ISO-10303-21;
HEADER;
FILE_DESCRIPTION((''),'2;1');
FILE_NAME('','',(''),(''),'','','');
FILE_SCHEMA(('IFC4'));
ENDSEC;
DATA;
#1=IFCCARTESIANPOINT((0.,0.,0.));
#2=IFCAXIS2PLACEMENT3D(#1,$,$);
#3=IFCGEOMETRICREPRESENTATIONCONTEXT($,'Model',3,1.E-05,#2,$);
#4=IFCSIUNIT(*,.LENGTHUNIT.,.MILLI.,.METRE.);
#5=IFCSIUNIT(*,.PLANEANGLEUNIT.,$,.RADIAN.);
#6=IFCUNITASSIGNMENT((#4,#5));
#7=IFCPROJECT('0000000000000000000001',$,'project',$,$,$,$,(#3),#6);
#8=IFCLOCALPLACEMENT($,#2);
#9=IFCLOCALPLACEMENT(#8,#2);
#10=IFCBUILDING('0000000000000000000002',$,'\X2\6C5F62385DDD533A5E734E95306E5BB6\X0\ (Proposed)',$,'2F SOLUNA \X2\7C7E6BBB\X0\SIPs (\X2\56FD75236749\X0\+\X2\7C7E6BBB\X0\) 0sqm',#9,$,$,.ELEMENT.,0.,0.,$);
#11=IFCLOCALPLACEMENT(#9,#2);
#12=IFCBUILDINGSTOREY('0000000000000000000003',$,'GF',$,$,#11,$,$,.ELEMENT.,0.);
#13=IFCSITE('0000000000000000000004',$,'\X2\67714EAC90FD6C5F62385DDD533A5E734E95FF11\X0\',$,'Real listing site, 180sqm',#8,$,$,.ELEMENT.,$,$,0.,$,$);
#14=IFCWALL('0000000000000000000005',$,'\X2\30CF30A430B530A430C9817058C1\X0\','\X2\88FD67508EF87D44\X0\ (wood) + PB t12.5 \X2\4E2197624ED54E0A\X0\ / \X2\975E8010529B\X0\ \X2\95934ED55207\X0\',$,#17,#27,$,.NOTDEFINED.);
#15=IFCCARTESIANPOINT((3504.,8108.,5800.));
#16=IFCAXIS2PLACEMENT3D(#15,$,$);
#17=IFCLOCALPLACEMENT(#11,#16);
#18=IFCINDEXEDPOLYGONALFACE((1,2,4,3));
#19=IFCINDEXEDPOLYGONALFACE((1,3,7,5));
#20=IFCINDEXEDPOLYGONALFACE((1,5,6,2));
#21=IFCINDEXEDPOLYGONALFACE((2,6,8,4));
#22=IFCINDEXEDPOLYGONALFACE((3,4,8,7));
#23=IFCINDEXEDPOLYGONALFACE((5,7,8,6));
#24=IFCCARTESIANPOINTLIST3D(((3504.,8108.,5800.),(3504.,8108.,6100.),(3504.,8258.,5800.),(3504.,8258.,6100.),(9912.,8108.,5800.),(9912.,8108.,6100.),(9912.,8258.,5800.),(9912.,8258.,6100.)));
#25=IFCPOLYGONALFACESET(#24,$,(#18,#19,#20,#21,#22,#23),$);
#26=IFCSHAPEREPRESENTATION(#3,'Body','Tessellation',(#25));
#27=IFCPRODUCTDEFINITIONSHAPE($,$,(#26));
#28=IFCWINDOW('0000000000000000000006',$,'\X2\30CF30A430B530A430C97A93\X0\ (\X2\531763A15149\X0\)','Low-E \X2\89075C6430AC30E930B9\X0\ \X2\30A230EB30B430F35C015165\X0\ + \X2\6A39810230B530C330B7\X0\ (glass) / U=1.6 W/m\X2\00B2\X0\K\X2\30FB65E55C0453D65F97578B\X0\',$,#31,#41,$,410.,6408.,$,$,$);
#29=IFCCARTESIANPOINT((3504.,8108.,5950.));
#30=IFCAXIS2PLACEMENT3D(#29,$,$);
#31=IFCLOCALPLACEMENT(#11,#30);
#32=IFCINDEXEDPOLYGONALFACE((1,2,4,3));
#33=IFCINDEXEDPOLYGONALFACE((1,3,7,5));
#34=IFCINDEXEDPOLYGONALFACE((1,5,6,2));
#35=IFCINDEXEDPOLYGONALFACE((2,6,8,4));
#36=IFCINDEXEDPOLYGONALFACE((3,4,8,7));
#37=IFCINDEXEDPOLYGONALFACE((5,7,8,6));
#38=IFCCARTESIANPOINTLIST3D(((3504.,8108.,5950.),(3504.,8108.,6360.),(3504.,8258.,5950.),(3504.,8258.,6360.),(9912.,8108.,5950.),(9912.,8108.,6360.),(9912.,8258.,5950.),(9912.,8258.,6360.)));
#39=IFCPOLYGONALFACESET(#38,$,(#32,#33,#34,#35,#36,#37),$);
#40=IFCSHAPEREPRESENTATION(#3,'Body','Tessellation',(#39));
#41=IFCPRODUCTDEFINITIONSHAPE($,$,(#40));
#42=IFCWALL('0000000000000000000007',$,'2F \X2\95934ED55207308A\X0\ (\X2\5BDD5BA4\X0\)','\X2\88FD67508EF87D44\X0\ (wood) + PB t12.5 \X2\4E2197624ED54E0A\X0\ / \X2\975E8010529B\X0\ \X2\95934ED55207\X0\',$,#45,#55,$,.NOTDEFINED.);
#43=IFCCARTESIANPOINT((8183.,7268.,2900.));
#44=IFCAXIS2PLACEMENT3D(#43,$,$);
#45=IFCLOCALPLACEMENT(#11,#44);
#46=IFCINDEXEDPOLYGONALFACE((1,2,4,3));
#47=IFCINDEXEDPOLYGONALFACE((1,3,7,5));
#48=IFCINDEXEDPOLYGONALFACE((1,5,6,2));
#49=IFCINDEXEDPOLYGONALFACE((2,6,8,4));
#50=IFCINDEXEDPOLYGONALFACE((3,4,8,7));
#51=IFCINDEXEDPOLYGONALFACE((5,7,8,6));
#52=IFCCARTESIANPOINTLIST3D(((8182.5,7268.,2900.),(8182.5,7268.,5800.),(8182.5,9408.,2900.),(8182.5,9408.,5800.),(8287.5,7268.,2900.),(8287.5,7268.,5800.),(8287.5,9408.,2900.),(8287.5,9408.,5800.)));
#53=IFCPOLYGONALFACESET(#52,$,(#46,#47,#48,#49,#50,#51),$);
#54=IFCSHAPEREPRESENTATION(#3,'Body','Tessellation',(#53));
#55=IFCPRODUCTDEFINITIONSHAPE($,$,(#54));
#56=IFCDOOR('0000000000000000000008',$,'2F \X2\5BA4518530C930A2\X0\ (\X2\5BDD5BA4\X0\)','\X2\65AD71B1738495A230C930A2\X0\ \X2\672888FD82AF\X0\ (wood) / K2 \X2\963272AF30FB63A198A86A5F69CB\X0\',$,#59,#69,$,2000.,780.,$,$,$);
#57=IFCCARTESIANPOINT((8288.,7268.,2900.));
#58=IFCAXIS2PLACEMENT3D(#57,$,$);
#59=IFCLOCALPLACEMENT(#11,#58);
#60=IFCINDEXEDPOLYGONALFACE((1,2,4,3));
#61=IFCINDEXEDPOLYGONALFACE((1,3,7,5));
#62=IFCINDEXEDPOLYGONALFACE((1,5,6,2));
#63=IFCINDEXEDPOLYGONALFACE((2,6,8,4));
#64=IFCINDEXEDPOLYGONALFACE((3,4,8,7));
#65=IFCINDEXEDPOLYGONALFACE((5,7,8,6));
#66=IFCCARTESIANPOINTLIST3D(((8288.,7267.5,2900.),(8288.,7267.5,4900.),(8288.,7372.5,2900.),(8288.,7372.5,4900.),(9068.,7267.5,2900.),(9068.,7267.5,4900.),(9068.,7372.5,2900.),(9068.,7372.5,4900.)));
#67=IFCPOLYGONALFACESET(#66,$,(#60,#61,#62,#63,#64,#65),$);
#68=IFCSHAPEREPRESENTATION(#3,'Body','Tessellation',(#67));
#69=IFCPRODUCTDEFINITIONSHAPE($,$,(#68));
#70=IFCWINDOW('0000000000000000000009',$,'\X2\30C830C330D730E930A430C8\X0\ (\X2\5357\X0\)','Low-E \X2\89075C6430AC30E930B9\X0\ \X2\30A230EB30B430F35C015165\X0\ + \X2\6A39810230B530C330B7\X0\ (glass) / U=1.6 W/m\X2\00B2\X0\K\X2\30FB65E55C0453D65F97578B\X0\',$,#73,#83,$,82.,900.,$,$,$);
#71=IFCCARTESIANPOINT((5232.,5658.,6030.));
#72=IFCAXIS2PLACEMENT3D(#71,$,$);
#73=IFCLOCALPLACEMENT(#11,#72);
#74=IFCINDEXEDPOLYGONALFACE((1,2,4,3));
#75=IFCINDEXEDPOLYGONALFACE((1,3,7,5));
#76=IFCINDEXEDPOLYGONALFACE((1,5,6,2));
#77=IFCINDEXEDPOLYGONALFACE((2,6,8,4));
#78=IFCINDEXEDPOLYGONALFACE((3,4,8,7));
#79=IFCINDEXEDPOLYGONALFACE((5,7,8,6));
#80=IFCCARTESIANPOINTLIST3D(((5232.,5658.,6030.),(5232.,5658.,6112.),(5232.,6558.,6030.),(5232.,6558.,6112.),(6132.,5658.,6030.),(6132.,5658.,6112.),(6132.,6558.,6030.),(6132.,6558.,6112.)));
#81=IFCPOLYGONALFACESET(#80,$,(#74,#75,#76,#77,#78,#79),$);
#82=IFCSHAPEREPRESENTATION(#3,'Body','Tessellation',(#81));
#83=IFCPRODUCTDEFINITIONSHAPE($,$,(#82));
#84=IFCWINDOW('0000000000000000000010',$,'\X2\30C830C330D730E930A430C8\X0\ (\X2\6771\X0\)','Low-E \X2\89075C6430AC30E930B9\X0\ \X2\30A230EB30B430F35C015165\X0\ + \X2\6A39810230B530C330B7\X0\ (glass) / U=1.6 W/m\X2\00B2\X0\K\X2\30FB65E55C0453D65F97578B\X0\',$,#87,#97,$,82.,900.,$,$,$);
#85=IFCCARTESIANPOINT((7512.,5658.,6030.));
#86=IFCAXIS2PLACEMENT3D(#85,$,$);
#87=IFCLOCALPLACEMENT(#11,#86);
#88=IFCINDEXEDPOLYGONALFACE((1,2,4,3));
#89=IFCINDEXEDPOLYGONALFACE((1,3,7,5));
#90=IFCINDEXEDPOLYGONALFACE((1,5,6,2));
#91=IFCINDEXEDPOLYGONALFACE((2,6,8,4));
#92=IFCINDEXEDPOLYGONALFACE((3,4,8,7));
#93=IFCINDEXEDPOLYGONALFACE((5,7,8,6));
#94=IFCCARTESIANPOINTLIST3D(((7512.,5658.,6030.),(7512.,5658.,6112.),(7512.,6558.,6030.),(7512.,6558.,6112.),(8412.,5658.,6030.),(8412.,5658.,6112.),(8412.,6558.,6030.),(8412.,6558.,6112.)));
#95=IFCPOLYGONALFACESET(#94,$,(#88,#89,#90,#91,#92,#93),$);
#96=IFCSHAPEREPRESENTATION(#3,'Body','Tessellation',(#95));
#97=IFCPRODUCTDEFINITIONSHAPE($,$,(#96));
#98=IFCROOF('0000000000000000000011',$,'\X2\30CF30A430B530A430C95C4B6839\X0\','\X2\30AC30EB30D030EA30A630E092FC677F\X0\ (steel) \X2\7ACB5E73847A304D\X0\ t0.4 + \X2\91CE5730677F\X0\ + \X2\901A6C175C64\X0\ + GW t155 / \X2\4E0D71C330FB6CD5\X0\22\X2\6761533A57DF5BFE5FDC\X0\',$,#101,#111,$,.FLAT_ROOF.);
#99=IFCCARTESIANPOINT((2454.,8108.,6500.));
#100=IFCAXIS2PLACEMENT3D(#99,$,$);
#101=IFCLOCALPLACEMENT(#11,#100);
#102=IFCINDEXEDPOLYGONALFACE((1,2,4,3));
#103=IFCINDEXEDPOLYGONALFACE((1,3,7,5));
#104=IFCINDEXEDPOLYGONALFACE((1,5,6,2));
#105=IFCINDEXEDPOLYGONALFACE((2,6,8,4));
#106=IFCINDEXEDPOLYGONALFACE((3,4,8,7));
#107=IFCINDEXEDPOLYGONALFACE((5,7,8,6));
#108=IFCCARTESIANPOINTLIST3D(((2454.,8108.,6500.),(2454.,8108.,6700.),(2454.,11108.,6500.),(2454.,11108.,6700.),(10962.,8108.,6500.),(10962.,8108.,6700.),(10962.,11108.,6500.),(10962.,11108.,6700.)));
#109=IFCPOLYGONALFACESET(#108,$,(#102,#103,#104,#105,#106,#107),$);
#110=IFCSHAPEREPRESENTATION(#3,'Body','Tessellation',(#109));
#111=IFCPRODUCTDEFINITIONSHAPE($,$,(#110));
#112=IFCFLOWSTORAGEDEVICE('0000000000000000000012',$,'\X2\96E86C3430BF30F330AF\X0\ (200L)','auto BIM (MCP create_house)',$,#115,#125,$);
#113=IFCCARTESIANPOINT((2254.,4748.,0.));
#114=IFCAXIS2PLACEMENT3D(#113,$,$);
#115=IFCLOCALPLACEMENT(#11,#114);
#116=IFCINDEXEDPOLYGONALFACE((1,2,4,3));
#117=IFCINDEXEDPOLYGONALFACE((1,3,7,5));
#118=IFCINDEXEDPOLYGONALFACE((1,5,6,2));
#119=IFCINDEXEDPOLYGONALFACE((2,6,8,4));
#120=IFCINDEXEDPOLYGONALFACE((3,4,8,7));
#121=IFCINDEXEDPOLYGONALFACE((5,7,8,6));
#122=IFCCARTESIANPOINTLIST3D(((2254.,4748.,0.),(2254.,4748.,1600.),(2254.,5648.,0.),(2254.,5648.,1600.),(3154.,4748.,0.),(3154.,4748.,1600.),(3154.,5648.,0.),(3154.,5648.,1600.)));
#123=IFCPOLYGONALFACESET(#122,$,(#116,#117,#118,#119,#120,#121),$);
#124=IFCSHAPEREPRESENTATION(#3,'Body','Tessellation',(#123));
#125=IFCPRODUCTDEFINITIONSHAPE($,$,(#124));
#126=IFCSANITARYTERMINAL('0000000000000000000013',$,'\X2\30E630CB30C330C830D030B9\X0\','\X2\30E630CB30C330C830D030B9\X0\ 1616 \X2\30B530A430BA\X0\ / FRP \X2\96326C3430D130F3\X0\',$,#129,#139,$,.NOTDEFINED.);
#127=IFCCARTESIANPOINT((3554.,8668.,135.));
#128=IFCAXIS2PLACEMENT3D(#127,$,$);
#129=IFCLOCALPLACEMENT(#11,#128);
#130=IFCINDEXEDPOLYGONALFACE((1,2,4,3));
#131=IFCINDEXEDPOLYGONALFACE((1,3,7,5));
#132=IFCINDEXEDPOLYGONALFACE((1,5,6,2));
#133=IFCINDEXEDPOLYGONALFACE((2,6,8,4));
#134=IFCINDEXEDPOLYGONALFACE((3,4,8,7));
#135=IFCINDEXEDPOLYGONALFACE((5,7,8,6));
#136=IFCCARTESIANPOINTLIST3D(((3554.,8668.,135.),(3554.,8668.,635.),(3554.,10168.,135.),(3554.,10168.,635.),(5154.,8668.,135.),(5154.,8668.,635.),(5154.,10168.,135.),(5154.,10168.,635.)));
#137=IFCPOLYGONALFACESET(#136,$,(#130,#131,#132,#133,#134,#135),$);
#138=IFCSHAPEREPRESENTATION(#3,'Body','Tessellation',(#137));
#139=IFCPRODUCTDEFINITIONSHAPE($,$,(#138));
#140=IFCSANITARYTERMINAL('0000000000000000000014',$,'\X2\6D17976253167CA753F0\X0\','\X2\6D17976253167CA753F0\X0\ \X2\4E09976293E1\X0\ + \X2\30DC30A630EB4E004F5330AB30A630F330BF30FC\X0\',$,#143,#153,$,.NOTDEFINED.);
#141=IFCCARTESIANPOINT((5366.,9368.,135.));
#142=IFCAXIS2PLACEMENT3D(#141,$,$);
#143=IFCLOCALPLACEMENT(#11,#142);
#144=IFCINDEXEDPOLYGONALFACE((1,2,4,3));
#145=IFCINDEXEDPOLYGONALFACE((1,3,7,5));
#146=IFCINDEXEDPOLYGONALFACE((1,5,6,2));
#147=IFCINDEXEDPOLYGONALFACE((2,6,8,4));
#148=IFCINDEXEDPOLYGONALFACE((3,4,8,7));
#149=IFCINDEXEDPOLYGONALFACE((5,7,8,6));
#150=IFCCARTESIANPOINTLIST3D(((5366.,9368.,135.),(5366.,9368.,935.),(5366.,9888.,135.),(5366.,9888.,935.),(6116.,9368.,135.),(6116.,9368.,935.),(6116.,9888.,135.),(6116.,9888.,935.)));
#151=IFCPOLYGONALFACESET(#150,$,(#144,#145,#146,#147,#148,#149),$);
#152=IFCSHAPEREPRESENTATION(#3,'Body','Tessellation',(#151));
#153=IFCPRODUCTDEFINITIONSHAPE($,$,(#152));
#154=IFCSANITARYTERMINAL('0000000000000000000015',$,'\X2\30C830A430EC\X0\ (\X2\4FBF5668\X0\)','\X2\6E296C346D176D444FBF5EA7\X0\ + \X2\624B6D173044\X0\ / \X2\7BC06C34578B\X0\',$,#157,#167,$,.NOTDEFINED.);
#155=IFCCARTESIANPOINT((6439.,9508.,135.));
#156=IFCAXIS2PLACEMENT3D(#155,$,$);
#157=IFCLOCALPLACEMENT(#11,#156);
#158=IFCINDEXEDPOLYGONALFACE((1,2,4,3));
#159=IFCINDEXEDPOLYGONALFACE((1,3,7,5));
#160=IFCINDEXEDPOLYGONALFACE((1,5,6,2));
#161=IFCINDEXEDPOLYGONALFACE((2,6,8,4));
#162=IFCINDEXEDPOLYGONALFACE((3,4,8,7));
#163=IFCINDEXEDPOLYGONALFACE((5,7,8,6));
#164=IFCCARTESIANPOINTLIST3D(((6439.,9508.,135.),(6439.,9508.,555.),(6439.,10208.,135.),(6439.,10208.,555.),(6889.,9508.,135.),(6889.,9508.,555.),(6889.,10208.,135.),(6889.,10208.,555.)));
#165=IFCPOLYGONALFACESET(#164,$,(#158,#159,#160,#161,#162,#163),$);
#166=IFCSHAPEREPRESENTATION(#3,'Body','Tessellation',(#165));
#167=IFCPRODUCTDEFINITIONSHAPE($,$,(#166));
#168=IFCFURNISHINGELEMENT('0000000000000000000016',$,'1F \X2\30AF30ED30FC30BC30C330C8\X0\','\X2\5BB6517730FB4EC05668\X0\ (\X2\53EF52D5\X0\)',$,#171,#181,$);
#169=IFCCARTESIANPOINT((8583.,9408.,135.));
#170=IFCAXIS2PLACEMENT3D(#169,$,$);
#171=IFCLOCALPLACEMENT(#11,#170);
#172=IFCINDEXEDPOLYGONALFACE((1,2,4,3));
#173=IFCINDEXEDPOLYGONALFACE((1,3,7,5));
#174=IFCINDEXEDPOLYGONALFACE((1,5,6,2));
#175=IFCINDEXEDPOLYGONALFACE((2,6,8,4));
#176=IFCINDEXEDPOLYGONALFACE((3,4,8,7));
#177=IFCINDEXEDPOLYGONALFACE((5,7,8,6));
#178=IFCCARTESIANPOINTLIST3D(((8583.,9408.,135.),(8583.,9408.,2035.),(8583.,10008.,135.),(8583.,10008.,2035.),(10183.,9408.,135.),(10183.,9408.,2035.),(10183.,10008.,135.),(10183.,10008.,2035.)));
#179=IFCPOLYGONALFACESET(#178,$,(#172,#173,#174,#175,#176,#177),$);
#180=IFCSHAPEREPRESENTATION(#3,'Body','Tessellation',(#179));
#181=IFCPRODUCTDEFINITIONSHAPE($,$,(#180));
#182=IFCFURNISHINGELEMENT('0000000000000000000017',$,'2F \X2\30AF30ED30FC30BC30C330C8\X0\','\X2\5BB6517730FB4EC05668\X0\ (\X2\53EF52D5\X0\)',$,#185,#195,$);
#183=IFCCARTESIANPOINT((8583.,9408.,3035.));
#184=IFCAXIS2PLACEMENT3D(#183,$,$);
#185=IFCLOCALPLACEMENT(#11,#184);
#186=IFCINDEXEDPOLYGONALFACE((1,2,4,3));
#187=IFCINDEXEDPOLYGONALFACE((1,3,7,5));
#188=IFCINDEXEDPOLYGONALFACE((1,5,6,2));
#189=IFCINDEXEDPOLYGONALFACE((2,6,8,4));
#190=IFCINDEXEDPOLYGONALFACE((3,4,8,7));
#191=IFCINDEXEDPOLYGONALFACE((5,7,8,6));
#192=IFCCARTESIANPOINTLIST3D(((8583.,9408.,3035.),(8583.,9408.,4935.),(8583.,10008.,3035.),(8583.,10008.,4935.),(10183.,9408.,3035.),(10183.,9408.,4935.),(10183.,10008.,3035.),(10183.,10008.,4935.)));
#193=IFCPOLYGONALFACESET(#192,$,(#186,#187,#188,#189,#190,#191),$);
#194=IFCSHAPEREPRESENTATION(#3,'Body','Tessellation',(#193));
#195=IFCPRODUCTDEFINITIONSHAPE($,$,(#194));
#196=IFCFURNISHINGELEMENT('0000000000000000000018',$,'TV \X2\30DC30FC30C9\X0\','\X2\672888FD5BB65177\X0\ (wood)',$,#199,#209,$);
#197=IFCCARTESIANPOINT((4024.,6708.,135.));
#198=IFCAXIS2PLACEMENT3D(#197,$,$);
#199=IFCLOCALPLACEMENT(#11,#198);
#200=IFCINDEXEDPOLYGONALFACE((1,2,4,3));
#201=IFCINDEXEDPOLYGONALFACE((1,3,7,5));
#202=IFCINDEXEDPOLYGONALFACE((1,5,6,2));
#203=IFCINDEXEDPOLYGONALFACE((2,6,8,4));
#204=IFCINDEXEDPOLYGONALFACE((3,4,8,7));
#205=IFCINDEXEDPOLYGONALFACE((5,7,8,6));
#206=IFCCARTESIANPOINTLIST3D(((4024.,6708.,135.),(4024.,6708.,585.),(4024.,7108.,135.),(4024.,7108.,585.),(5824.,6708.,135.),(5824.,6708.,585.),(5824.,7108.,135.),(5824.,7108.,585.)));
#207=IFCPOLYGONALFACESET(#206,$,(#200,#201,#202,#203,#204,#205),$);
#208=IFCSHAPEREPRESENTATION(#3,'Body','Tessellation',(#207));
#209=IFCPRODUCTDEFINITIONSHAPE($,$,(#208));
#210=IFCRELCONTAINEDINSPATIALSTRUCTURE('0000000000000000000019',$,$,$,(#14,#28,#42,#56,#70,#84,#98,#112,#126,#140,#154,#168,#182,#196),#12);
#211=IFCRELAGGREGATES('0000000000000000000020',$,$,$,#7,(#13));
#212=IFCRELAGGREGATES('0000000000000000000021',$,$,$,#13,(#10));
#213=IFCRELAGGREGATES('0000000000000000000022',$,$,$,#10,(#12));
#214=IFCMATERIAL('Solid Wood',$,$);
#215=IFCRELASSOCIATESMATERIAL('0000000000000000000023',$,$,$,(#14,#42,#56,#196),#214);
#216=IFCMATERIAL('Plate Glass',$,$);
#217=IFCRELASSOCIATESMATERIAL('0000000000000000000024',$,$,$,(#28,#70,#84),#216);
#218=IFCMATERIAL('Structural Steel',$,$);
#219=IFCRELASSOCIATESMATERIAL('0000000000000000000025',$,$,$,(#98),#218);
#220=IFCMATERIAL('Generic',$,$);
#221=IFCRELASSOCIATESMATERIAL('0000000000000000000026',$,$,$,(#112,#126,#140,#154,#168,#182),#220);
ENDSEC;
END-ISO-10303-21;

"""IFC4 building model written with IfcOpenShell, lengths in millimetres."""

from ifc_helpers import new_model, si_unit, frame, frame_2d, origin, place, context, project, spatial, rectangle, extrude, material, element, fill, save


model = new_model("IFC4")

# Units and contexts
model_context = context("Model", 3, precision=1e-05, world=origin())
ifc_project = project(units=[si_unit("LENGTHUNIT", "METRE", prefix="MILLI"), si_unit("PLANEANGLEUNIT", "RADIAN")], contexts=[model_context])

# Site, building, storey
site_placement = place(None, origin())
site = spatial("IfcSite", under=ifc_project, at=site_placement, Name="東京都江戸川区平井１", ObjectType="Real listing site, 180sqm", CompositionType="ELEMENT", RefElevation=0.0)
building_placement = place(site_placement, origin())
building = spatial("IfcBuilding", under=site, at=building_placement, Name="江戸川区平井の家 (Proposed)", ObjectType="2F SOLUNA 籾殻SIPs (国産杉+籾殻) 0sqm", CompositionType="ELEMENT", ElevationOfRefHeight=0.0, ElevationOfTerrain=0.0)
storey_placement = place(building_placement, origin())
storey = spatial("IfcBuildingStorey", under=building, at=storey_placement, Name="GF", CompositionType="ELEMENT", Elevation=0.0)

# Shared definitions
ifc_material_1 = material(Name="Solid Wood")
ifc_material_2 = material(Name="Plate Glass")

# Wall, opening, window
wall_1_placement = place(storey_placement, frame((3504.0, 8108.0, 5800.0)))
wall_1 = element("IfcWall", 1, at=wall_1_placement, inside=storey, material=ifc_material_1, Name="ハイサイド腰壁", Description="製材軸組 (wood) + PB t12.5 両面仕上 / 非耐力 間仕切", PredefinedType="NOTDEFINED", context=model_context, shape_type="SweptSolid", body=[
    extrude(rectangle(XDim=6408.0, YDim=150.0, at=frame_2d((3204.0, 75.0))), frame((3504.0, 8108.0, 5800.0)), (0.0, 0.0, 1.0), 700.0),
])
opening_1_placement = place(storey_placement, frame((3504.0, 8108.0, 5950.0)))
opening_1 = element("IfcOpeningElement", 2, at=opening_1_placement, cuts=wall_1, PredefinedType="NOTDEFINED", context=model_context, shape_type="SweptSolid", body=[
    extrude(rectangle(XDim=6408.0, YDim=150.0, at=frame_2d((3204.0, 75.0))), frame((3504.0, 8108.0, 5950.0)), (0.0, 0.0, 1.0), 410.0),
])
window_1_placement = place(storey_placement, frame((3504.0, 8108.0, 5950.0)))
window_1 = element("IfcWindow", 3, at=window_1_placement, inside=storey, material=ifc_material_2, Name="ハイサイド窓 (北採光)", Description="Low-E 複層ガラス アルゴン封入 + 樹脂サッシ (glass) / U=1.6 W/m²K・日射取得型", OverallHeight=410.0, OverallWidth=6408.0, context=model_context, shape_type="SweptSolid", body=[
    extrude(rectangle(XDim=6408.0, YDim=150.0, at=frame_2d((3204.0, 75.0))), frame((3504.0, 8108.0, 5950.0)), (0.0, 0.0, 1.0), 410.0),
])
fill(opening_1, window_1)

# Wall
wall_2_placement = place(storey_placement, frame((8183.0, 7268.0, 2900.0)))
element("IfcWall", 4, at=wall_2_placement, inside=storey, material=ifc_material_1, Name="2F 間仕切り (寝室)", Description="製材軸組 (wood) + PB t12.5 両面仕上 / 非耐力 間仕切", PredefinedType="NOTDEFINED", context=model_context, shape_type="SweptSolid", body=[
    extrude(rectangle(XDim=105.0, YDim=2140.0, at=frame_2d((52.0, 1070.0))), frame((8183.0, 7268.0, 2900.0)), (0.0, 0.0, 1.0), 2900.0),
])

# Door
door_1_placement = place(storey_placement, frame((8288.0, 7268.0, 2900.0)))
element("IfcDoor", 5, at=door_1_placement, inside=storey, material=ifc_material_1, Name="2F 室内ドア (寝室)", Description="断熱玄関ドア 木製芯 (wood) / K2 防犯・採風機構", OverallHeight=2000.0, OverallWidth=780.0, context=model_context, shape_type="SweptSolid", body=[
    extrude(rectangle(XDim=780.0, YDim=105.0, at=frame_2d((390.0, 52.0))), frame((8288.0, 7268.0, 2900.0)), (0.0, 0.0, 1.0), 2000.0),
])

# Windows
window_2_placement = place(storey_placement, frame((5232.0, 5658.0, 6030.0)))
element("IfcWindow", 6, at=window_2_placement, inside=storey, material=ifc_material_2, Name="トップライト (南)", Description="Low-E 複層ガラス アルゴン封入 + 樹脂サッシ (glass) / U=1.6 W/m²K・日射取得型", OverallHeight=82.0, OverallWidth=900.0, context=model_context, shape_type="SweptSolid", body=[
    extrude(rectangle(XDim=900.0, YDim=900.0, at=frame_2d((450.0, 450.0))), frame((5232.0, 5658.0, 6030.0)), (0.0, 0.0, 1.0), 82.0),
])
window_3_placement = place(storey_placement, frame((7512.0, 5658.0, 6030.0)))
element("IfcWindow", 7, at=window_3_placement, inside=storey, material=ifc_material_2, Name="トップライト (東)", Description="Low-E 複層ガラス アルゴン封入 + 樹脂サッシ (glass) / U=1.6 W/m²K・日射取得型", OverallHeight=82.0, OverallWidth=900.0, context=model_context, shape_type="SweptSolid", body=[
    extrude(rectangle(XDim=900.0, YDim=900.0, at=frame_2d((450.0, 450.0))), frame((7512.0, 5658.0, 6030.0)), (0.0, 0.0, 1.0), 82.0),
])

# Roof
ifc_material_3 = material(Name="Structural Steel")
roof_placement = place(storey_placement, frame((2454.0, 8108.0, 6500.0)))
element("IfcRoof", 8, at=roof_placement, inside=storey, material=ifc_material_3, Name="ハイサイド屋根", Description="ガルバリウム鋼板 (steel) 立平葺き t0.4 + 野地板 + 通気層 + GW t155 / 不燃・法22条区域対応", PredefinedType="FLAT_ROOF", context=model_context, shape_type="SweptSolid", body=[
    extrude(rectangle(XDim=8508.0, YDim=3000.0, at=frame_2d((4254.0, 1500.0))), frame((2454.0, 8108.0, 6500.0)), (0.0, 0.0, 1.0), 200.0),
])

# Flow storage device
ifc_material_4 = material(Name="Generic")
flow_storage_device_placement = place(storey_placement, frame((2254.0, 4748.0, 0.0)))
element("IfcFlowStorageDevice", 9, at=flow_storage_device_placement, inside=storey, material=ifc_material_4, Name="雨水タンク (200L)", Description="auto BIM (MCP create_house)", context=model_context, shape_type="SweptSolid", body=[
    extrude(rectangle(XDim=900.0, YDim=900.0, at=frame_2d((450.0, 450.0))), frame((2254.0, 4748.0, 0.0)), (0.0, 0.0, 1.0), 1600.0),
])

# Sanitary terminals
sanitary_terminal_1_placement = place(storey_placement, frame((3554.0, 8668.0, 135.0)))
element("IfcSanitaryTerminal", 10, at=sanitary_terminal_1_placement, inside=storey, material=ifc_material_4, Name="ユニットバス", Description="ユニットバス 1616 サイズ / FRP 防水パン", PredefinedType="NOTDEFINED", context=model_context, shape_type="SweptSolid", body=[
    extrude(rectangle(XDim=1600.0, YDim=1500.0, at=frame_2d((800.0, 750.0))), frame((3554.0, 8668.0, 135.0)), (0.0, 0.0, 1.0), 500.0),
])
sanitary_terminal_2_placement = place(storey_placement, frame((5366.0, 9368.0, 135.0)))
element("IfcSanitaryTerminal", 11, at=sanitary_terminal_2_placement, inside=storey, material=ifc_material_4, Name="洗面化粧台", Description="洗面化粧台 三面鏡 + ボウル一体カウンター", PredefinedType="NOTDEFINED", context=model_context, shape_type="SweptSolid", body=[
    extrude(rectangle(XDim=750.0, YDim=520.0, at=frame_2d((375.0, 260.0))), frame((5366.0, 9368.0, 135.0)), (0.0, 0.0, 1.0), 800.0),
])
sanitary_terminal_3_placement = place(storey_placement, frame((6439.0, 9508.0, 135.0)))
element("IfcSanitaryTerminal", 12, at=sanitary_terminal_3_placement, inside=storey, material=ifc_material_4, Name="トイレ (便器)", Description="温水洗浄便座 + 手洗い / 節水型", PredefinedType="NOTDEFINED", context=model_context, shape_type="SweptSolid", body=[
    extrude(rectangle(XDim=450.0, YDim=700.0, at=frame_2d((225.0, 350.0))), frame((6439.0, 9508.0, 135.0)), (0.0, 0.0, 1.0), 420.0),
])

# Furnishing elements
furnishing_1_placement = place(storey_placement, frame((8583.0, 9408.0, 135.0)))
element("IfcFurnishingElement", 13, at=furnishing_1_placement, inside=storey, material=ifc_material_4, Name="1F クローゼット", Description="家具・什器 (可動)", context=model_context, shape_type="SweptSolid", body=[
    extrude(rectangle(XDim=1600.0, YDim=600.0, at=frame_2d((800.0, 300.0))), frame((8583.0, 9408.0, 135.0)), (0.0, 0.0, 1.0), 1900.0),
])
furnishing_2_placement = place(storey_placement, frame((8583.0, 9408.0, 3035.0)))
element("IfcFurnishingElement", 14, at=furnishing_2_placement, inside=storey, material=ifc_material_4, Name="2F クローゼット", Description="家具・什器 (可動)", context=model_context, shape_type="SweptSolid", body=[
    extrude(rectangle(XDim=1600.0, YDim=600.0, at=frame_2d((800.0, 300.0))), frame((8583.0, 9408.0, 3035.0)), (0.0, 0.0, 1.0), 1900.0),
])
furnishing_3_placement = place(storey_placement, frame((4024.0, 6708.0, 135.0)))
element("IfcFurnishingElement", 15, at=furnishing_3_placement, inside=storey, material=ifc_material_1, Name="TV ボード", Description="木製家具 (wood)", context=model_context, shape_type="SweptSolid", body=[
    extrude(rectangle(XDim=1800.0, YDim=400.0, at=frame_2d((900.0, 200.0))), frame((4024.0, 6708.0, 135.0)), (0.0, 0.0, 1.0), 450.0),
])

save(model, "model.ifc")
